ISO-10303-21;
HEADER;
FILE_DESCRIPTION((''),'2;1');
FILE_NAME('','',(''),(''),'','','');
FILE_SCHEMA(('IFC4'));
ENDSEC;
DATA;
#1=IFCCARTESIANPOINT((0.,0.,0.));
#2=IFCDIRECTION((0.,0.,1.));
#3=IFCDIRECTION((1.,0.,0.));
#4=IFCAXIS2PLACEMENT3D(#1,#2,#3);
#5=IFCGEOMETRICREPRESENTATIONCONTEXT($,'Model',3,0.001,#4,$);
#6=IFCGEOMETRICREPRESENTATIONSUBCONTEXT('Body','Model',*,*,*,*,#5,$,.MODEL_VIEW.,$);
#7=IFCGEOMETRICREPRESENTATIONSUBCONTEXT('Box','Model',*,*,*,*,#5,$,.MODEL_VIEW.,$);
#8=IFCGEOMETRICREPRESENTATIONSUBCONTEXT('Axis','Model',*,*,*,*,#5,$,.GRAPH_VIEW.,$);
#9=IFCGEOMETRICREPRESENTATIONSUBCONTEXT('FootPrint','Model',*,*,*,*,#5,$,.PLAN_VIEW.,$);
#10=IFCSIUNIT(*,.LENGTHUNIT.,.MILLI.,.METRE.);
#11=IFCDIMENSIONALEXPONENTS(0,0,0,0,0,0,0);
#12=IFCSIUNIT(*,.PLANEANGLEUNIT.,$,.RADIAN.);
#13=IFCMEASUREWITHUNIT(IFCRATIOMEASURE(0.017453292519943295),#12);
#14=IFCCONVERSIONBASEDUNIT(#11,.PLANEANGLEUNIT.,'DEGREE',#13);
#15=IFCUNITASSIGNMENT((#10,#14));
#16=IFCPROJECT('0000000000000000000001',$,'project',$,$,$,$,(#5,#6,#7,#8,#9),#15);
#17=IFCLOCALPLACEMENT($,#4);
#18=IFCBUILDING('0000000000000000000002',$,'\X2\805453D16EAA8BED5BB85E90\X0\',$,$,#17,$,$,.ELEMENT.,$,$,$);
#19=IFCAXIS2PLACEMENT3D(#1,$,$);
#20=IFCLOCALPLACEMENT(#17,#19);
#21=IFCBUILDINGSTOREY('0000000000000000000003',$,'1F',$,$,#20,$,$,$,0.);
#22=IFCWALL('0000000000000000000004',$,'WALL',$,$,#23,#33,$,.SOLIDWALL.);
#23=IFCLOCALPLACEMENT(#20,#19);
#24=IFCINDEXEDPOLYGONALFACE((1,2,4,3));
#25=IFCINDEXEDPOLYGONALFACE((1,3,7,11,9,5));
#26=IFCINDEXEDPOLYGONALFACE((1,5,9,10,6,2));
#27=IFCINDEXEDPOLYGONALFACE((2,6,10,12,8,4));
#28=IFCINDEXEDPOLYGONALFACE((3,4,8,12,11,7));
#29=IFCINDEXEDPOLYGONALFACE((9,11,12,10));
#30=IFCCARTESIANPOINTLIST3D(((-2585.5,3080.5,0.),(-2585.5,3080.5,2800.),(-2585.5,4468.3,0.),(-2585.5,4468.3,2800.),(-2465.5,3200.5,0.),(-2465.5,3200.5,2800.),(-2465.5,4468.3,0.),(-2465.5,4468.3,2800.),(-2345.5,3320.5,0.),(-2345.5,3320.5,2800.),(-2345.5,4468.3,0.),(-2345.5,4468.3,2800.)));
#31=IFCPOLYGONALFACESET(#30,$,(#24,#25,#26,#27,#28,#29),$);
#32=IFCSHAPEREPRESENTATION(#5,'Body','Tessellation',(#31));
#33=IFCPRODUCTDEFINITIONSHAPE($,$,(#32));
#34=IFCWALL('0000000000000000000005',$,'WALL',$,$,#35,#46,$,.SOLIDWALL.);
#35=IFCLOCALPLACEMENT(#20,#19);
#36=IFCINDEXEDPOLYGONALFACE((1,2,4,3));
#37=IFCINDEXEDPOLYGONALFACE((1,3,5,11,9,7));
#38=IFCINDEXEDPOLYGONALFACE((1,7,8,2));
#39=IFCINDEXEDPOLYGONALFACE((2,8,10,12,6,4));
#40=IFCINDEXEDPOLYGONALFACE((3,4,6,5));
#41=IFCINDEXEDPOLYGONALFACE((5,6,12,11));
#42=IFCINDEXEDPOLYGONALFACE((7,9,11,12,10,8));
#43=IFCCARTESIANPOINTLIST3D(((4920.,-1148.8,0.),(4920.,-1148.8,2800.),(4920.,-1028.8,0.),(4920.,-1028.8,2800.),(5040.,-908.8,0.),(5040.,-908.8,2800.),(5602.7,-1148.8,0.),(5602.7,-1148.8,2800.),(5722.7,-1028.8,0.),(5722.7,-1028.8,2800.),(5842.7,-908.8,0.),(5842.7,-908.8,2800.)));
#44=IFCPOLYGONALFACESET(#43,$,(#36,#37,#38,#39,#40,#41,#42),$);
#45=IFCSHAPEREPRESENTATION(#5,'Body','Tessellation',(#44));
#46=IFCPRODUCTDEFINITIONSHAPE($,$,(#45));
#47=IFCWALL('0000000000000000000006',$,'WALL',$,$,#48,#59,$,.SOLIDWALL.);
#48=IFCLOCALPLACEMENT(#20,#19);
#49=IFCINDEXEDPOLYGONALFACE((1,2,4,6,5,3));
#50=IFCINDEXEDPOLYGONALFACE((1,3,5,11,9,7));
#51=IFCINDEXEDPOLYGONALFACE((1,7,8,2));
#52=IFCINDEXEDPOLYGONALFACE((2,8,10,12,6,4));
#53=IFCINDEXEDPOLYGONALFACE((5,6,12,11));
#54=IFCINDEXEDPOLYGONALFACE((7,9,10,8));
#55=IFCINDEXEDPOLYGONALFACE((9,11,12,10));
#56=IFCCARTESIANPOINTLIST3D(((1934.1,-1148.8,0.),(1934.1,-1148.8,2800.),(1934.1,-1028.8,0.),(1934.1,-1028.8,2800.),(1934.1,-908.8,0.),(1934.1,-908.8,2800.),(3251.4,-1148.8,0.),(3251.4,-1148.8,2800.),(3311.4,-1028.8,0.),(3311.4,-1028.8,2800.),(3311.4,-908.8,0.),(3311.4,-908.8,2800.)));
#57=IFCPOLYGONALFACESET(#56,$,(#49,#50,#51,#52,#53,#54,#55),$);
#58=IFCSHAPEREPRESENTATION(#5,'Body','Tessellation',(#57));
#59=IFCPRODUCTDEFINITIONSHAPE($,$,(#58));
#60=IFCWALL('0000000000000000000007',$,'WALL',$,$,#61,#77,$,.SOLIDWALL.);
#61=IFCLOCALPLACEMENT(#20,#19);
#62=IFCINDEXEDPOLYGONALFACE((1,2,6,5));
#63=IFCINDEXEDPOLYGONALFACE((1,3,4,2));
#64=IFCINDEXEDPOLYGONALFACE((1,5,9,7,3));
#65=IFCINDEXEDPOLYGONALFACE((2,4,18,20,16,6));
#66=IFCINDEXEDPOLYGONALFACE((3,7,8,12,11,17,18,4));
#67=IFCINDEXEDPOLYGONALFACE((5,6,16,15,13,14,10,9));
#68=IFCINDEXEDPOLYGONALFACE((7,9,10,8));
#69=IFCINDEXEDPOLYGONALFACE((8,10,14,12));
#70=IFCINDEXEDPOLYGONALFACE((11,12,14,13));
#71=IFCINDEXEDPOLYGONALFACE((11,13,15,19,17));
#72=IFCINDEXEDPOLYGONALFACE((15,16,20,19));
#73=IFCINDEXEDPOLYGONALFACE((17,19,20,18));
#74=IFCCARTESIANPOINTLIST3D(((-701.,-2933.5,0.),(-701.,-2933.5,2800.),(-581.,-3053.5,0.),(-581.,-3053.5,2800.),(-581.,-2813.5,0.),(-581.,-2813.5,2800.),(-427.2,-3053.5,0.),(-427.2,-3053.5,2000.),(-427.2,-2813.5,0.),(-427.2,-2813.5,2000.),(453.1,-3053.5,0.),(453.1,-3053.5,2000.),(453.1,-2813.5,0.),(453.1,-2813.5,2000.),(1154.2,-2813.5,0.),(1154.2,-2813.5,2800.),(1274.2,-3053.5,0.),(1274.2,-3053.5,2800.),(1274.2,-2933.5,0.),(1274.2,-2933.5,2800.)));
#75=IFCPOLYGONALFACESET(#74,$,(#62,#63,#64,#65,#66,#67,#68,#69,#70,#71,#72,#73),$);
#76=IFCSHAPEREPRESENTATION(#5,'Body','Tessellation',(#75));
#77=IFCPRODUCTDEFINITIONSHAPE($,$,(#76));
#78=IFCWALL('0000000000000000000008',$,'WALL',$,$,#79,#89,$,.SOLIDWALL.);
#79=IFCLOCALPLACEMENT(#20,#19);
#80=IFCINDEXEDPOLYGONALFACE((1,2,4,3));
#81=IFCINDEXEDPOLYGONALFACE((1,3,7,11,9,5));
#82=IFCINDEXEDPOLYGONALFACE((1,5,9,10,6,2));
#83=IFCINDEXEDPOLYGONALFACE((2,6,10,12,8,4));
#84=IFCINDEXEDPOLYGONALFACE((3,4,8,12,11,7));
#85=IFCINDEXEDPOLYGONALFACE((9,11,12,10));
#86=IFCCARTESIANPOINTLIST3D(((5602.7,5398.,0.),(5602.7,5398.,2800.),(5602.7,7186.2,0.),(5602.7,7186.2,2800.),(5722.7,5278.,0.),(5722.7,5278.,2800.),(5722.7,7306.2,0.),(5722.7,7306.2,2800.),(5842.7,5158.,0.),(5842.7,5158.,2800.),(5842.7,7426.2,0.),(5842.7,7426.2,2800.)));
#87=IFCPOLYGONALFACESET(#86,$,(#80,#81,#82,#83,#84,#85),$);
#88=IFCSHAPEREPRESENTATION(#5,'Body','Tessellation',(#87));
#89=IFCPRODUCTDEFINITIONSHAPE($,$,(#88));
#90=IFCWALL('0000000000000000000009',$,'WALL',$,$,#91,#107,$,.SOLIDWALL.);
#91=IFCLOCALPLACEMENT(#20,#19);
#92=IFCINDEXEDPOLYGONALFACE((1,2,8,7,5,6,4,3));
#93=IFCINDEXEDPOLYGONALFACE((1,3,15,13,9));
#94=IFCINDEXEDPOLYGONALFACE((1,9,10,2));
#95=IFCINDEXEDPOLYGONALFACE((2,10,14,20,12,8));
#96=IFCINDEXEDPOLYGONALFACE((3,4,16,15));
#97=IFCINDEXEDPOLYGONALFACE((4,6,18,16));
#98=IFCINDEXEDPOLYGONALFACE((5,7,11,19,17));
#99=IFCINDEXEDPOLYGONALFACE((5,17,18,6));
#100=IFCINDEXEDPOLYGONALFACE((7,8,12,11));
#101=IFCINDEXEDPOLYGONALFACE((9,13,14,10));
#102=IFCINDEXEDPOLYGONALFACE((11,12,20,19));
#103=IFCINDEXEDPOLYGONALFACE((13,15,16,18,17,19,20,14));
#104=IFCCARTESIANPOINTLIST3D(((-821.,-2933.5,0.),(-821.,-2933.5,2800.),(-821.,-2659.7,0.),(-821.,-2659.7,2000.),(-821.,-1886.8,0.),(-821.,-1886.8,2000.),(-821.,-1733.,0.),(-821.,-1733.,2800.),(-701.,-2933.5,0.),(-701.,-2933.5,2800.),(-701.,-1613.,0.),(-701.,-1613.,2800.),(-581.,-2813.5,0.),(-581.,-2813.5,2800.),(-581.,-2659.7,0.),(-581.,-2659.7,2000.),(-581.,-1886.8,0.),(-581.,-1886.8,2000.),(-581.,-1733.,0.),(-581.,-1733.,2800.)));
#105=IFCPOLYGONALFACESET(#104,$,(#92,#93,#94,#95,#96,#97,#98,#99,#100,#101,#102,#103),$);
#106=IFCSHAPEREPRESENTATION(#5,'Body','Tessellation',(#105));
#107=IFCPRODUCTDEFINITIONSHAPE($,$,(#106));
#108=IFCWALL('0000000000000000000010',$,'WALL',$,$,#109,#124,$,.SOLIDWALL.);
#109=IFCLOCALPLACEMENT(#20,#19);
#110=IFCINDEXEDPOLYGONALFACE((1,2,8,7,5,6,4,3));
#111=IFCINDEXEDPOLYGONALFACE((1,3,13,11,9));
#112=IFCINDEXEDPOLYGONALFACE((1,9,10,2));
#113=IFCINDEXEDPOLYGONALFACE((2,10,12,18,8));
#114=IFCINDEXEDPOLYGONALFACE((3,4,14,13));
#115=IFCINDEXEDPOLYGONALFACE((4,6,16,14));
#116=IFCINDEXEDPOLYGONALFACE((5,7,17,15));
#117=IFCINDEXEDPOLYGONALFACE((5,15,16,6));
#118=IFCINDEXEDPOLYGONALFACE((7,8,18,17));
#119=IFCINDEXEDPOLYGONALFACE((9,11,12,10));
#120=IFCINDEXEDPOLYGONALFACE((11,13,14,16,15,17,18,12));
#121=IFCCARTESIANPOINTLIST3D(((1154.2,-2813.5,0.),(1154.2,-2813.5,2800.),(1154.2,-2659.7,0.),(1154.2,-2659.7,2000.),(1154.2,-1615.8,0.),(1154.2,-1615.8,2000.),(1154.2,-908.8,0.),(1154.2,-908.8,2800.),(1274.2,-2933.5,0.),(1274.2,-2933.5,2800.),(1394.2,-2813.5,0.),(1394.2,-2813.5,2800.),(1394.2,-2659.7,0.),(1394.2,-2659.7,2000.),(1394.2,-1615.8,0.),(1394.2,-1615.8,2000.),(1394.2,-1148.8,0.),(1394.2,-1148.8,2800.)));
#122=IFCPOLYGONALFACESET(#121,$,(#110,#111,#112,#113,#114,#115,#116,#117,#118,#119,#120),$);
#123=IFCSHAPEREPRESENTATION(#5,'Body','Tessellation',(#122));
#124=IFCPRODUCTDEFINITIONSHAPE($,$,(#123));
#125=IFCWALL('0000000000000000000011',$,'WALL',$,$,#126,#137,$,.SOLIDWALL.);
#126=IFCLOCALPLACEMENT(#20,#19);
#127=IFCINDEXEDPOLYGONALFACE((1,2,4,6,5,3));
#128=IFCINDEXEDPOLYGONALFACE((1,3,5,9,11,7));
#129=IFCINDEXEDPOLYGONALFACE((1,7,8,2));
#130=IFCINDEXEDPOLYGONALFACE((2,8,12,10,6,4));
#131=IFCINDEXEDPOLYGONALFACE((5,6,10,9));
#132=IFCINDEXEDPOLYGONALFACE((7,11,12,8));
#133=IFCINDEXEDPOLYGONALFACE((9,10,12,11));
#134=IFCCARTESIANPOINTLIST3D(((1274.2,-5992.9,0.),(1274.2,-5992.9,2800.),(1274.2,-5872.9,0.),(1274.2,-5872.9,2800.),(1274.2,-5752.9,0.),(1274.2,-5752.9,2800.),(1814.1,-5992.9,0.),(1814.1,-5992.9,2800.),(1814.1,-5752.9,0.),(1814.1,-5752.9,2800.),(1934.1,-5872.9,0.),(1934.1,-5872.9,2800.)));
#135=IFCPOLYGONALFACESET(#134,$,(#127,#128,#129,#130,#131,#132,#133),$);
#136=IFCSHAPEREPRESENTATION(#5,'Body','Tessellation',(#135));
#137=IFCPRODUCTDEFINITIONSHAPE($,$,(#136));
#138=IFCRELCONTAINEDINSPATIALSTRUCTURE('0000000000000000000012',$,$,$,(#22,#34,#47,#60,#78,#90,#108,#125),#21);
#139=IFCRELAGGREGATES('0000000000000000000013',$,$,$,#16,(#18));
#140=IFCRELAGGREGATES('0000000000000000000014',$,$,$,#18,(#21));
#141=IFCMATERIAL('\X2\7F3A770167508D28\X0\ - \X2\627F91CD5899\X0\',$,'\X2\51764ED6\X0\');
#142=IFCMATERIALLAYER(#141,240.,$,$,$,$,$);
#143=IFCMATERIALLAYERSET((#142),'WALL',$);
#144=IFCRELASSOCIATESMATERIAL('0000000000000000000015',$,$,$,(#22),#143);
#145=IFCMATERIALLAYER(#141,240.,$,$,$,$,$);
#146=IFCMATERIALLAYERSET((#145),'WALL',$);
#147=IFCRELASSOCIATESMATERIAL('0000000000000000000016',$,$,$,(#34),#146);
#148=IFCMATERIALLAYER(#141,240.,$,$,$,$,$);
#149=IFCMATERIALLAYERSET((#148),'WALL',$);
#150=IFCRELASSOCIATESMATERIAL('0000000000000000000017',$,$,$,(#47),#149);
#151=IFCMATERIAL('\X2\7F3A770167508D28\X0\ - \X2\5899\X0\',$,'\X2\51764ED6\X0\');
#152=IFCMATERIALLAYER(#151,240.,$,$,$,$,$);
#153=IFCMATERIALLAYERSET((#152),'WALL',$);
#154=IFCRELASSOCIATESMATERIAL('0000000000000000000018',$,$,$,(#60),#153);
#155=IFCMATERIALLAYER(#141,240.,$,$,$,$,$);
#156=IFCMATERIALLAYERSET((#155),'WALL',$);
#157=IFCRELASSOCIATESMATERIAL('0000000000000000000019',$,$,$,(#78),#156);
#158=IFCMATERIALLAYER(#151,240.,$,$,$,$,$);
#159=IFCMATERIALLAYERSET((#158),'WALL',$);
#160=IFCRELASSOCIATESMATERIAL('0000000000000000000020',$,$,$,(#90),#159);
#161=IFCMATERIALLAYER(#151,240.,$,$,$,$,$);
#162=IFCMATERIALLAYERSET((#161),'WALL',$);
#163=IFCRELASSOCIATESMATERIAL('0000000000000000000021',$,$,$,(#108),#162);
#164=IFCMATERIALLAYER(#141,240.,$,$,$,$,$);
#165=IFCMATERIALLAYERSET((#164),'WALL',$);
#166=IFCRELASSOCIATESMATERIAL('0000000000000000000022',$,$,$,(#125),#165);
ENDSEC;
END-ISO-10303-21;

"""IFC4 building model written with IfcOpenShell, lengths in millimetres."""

from ifc_helpers import new_model, entity, si_unit, converted_unit, origin, origin_with_axes, place, context, subcontext, project, spatial, polyline, segment, composite_curve, outline, extrude, material, layer, layer_set, layer_usage, element, save


model = new_model("IFC4")

# Units and contexts
model_context = context("Model", 3, precision=0.001, world=origin_with_axes())
body_context = subcontext(model_context, "Body", "Model", "MODEL_VIEW")
box_context = subcontext(model_context, "Box", "Model", "MODEL_VIEW")
axis_context = subcontext(model_context, "Axis", "Model", "GRAPH_VIEW")
footprint_context = subcontext(model_context, "FootPrint", "Model", "PLAN_VIEW")
ifc_project = project(units=[si_unit("LENGTHUNIT", "METRE", prefix="MILLI"), converted_unit("PLANEANGLEUNIT", "DEGREE", entity("IfcRatioMeasure", 0.017453292519943295), si_unit("PLANEANGLEUNIT", "RADIAN"), dimensions=[0, 0, 0, 0, 0, 0, 0])], contexts=[model_context, body_context, box_context, axis_context, footprint_context])

# Building, storey
building_placement = place(None, origin_with_axes())
building = spatial("IfcBuilding", under=ifc_project, at=building_placement, Name="联发溪语宸庐", CompositionType="ELEMENT")
storey_placement = place(building_placement, origin())
storey = spatial("IfcBuildingStorey", under=building, at=storey_placement, Name="1F", Elevation=0.0)

# Walls
ifc_material_1 = material(Name="缺省材质 - 承重墙", Category="其他")
ifc_layer_1 = layer(ifc_material_1, 240.0)
ifc_layer_set_1 = layer_set([ifc_layer_1], Name="WALL")
ifc_layer_usage_1 = layer_usage(ifc_layer_set_1, "AXIS2", "NEGATIVE", 120.0)
wall_1_placement = place(None, origin_with_axes())
element("IfcWall", 1, at=wall_1_placement, inside=storey, material=ifc_layer_usage_1, Name="WALL", PredefinedType="SOLIDWALL", context=model_context, shape_type="SweptSolid", body=[
    extrude(outline(composite_curve([segment(polyline([(-2465.5, 3200.5), (-2345.5, 3320.5)]), True, "CONTINUOUS"), segment(polyline([(-2345.5, 3320.5), (-2345.5, 4468.3)]), True, "CONTINUOUS"), segment(polyline([(-2345.5, 4468.3), (-2465.5, 4468.3)]), True, "CONTINUOUS"), segment(polyline([(-2465.5, 4468.3), (-2585.5, 4468.3)]), True, "CONTINUOUS"), segment(polyline([(-2585.5, 4468.3), (-2585.5, 3080.5)]), True, "CONTINUOUS"), segment(polyline([(-2585.5, 3080.5), (-2465.5, 3200.5)]), True, "CONTINUOUS")], self_intersect=False)), origin(), (0.0, 0.0, 1.0), 2800.0),
])
ifc_layer_2 = layer(ifc_material_1, 240.0)
ifc_layer_set_2 = layer_set([ifc_layer_2], Name="WALL")
ifc_layer_usage_2 = layer_usage(ifc_layer_set_2, "AXIS2", "NEGATIVE", 120.0)
wall_2_placement = place(None, origin_with_axes())
element("IfcWall", 2, at=wall_2_placement, inside=storey, material=ifc_layer_usage_2, Name="WALL", PredefinedType="SOLIDWALL", context=model_context, shape_type="SweptSolid", body=[
    extrude(outline(composite_curve([segment(polyline([(5722.7, -1028.8), (5842.7, -908.8)]), True, "CONTINUOUS"), segment(polyline([(5842.7, -908.8), (5040.0, -908.8)]), True, "CONTINUOUS"), segment(polyline([(5040.0, -908.8), (4920.0, -1028.8)]), True, "CONTINUOUS"), segment(polyline([(4920.0, -1028.8), (4920.0, -1148.8)]), True, "CONTINUOUS"), segment(polyline([(4920.0, -1148.8), (5602.7, -1148.8)]), True, "CONTINUOUS"), segment(polyline([(5602.7, -1148.8), (5722.7, -1028.8)]), True, "CONTINUOUS")], self_intersect=False)), origin(), (0.0, 0.0, 1.0), 2800.0),
])
ifc_layer_3 = layer(ifc_material_1, 240.0)
ifc_layer_set_3 = layer_set([ifc_layer_3], Name="WALL")
ifc_layer_usage_3 = layer_usage(ifc_layer_set_3, "AXIS2", "NEGATIVE", 120.0)
wall_3_placement = place(None, origin_with_axes())
element("IfcWall", 3, at=wall_3_placement, inside=storey, material=ifc_layer_usage_3, Name="WALL", PredefinedType="SOLIDWALL", context=model_context, shape_type="SweptSolid", body=[
    extrude(outline(composite_curve([segment(polyline([(3311.4, -1028.8), (3311.4, -908.8)]), True, "CONTINUOUS"), segment(polyline([(3311.4, -908.8), (1934.1, -908.8)]), True, "CONTINUOUS"), segment(polyline([(1934.1, -908.8), (1934.1, -1028.8)]), True, "CONTINUOUS"), segment(polyline([(1934.1, -1028.8), (1934.1, -1148.8)]), True, "CONTINUOUS"), segment(polyline([(1934.1, -1148.8), (3251.4, -1148.8)]), True, "CONTINUOUS"), segment(polyline([(3251.4, -1148.8), (3311.4, -1028.8)]), True, "CONTINUOUS")], self_intersect=False)), origin(), (0.0, 0.0, 1.0), 2800.0),
])

# Wall, opening
ifc_material_2 = material(Name="缺省材质 - 墙", Category="其他")
ifc_layer_4 = layer(ifc_material_2, 240.0)
ifc_layer_set_4 = layer_set([ifc_layer_4], Name="WALL")
ifc_layer_usage_4 = layer_usage(ifc_layer_set_4, "AXIS2", "NEGATIVE", 120.0)
wall_4_placement = place(None, origin_with_axes())
wall_4 = element("IfcWall", 4, at=wall_4_placement, inside=storey, material=ifc_layer_usage_4, Name="WALL", PredefinedType="SOLIDWALL", context=model_context, shape_type="SweptSolid", body=[
    extrude(outline(composite_curve([segment(polyline([(-701.0, -2933.5), (-581.0, -3053.5)]), True, "CONTINUOUS"), segment(polyline([(-581.0, -3053.5), (1274.2, -3053.5)]), True, "CONTINUOUS"), segment(polyline([(1274.2, -3053.5), (1274.2, -2933.5)]), True, "CONTINUOUS"), segment(polyline([(1274.2, -2933.5), (1154.2, -2813.5)]), True, "CONTINUOUS"), segment(polyline([(1154.2, -2813.5), (-581.0, -2813.5)]), True, "CONTINUOUS"), segment(polyline([(-581.0, -2813.5), (-701.0, -2933.5)]), True, "CONTINUOUS")], self_intersect=False)), origin(), (0.0, 0.0, 1.0), 2800.0),
])
opening_1_placement = place(None, origin_with_axes())
element("IfcOpeningElement", 5, at=opening_1_placement, cuts=wall_4, ObjectType="OPENING", PredefinedType="OPENING", context=model_context, shape_type="SweptSolid", body=[
    extrude(outline(composite_curve([segment(polyline([(453.1, -2813.5), (-427.2, -2813.5)]), True, "CONTINUOUS"), segment(polyline([(-427.2, -2813.5), (-427.2, -3053.5)]), True, "CONTINUOUS"), segment(polyline([(-427.2, -3053.5), (453.1, -3053.5)]), True, "CONTINUOUS"), segment(polyline([(453.1, -3053.5), (453.1, -2813.5)]), True, "CONTINUOUS")], self_intersect=False)), origin_with_axes(), (0.0, 0.0, 1.0), 2000.0),
])

# Wall
ifc_layer_5 = layer(ifc_material_1, 240.0)
ifc_layer_set_5 = layer_set([ifc_layer_5], Name="WALL")
ifc_layer_usage_5 = layer_usage(ifc_layer_set_5, "AXIS2", "NEGATIVE", 120.0)
wall_5_placement = place(None, origin_with_axes())
element("IfcWall", 6, at=wall_5_placement, inside=storey, material=ifc_layer_usage_5, Name="WALL", PredefinedType="SOLIDWALL", context=model_context, shape_type="SweptSolid", body=[
    extrude(outline(composite_curve([segment(polyline([(5722.7, 5278.0), (5842.7, 5158.0)]), True, "CONTINUOUS"), segment(polyline([(5842.7, 5158.0), (5842.7, 7426.2)]), True, "CONTINUOUS"), segment(polyline([(5842.7, 7426.2), (5722.7, 7306.2)]), True, "CONTINUOUS"), segment(polyline([(5722.7, 7306.2), (5602.7, 7186.2)]), True, "CONTINUOUS"), segment(polyline([(5602.7, 7186.2), (5602.7, 5398.0)]), True, "CONTINUOUS"), segment(polyline([(5602.7, 5398.0), (5722.7, 5278.0)]), True, "CONTINUOUS")], self_intersect=False)), origin(), (0.0, 0.0, 1.0), 2800.0),
])

# Walls, openings
ifc_layer_6 = layer(ifc_material_2, 240.0)
ifc_layer_set_6 = layer_set([ifc_layer_6], Name="WALL")
ifc_layer_usage_6 = layer_usage(ifc_layer_set_6, "AXIS2", "NEGATIVE", 120.0)
wall_6_placement = place(None, origin_with_axes())
wall_6 = element("IfcWall", 7, at=wall_6_placement, inside=storey, material=ifc_layer_usage_6, Name="WALL", PredefinedType="SOLIDWALL", context=model_context, shape_type="SweptSolid", body=[
    extrude(outline(composite_curve([segment(polyline([(-701.0, -2933.5), (-581.0, -2813.5)]), True, "CONTINUOUS"), segment(polyline([(-581.0, -2813.5), (-581.0, -1733.0)]), True, "CONTINUOUS"), segment(polyline([(-581.0, -1733.0), (-701.0, -1613.0)]), True, "CONTINUOUS"), segment(polyline([(-701.0, -1613.0), (-821.0, -1733.0)]), True, "CONTINUOUS"), segment(polyline([(-821.0, -1733.0), (-821.0, -2933.5)]), True, "CONTINUOUS"), segment(polyline([(-821.0, -2933.5), (-701.0, -2933.5)]), True, "CONTINUOUS")], self_intersect=False)), origin(), (0.0, 0.0, 1.0), 2800.0),
])
opening_2_placement = place(None, origin_with_axes())
element("IfcOpeningElement", 8, at=opening_2_placement, cuts=wall_6, ObjectType="OPENING", PredefinedType="OPENING", context=model_context, shape_type="SweptSolid", body=[
    extrude(outline(composite_curve([segment(polyline([(-821.0, -1886.8), (-821.0, -2659.7)]), True, "CONTINUOUS"), segment(polyline([(-821.0, -2659.7), (-581.0, -2659.7)]), True, "CONTINUOUS"), segment(polyline([(-581.0, -2659.7), (-581.0, -1886.8)]), True, "CONTINUOUS"), segment(polyline([(-581.0, -1886.8), (-821.0, -1886.8)]), True, "CONTINUOUS")], self_intersect=False)), origin_with_axes(), (0.0, 0.0, 1.0), 2000.0),
])
ifc_layer_7 = layer(ifc_material_2, 240.0)
ifc_layer_set_7 = layer_set([ifc_layer_7], Name="WALL")
ifc_layer_usage_7 = layer_usage(ifc_layer_set_7, "AXIS2", "NEGATIVE", 120.0)
wall_7_placement = place(None, origin_with_axes())
wall_7 = element("IfcWall", 9, at=wall_7_placement, inside=storey, material=ifc_layer_usage_7, Name="WALL", PredefinedType="SOLIDWALL", context=model_context, shape_type="SweptSolid", body=[
    extrude(outline(composite_curve([segment(polyline([(1274.2, -2933.5), (1394.2, -2813.5)]), True, "CONTINUOUS"), segment(polyline([(1394.2, -2813.5), (1394.2, -1148.8)]), True, "CONTINUOUS"), segment(polyline([(1394.2, -1148.8), (1274.2, -1028.8)]), True, "CONTINUOUS"), segment(polyline([(1274.2, -1028.8), (1154.2, -908.8)]), True, "CONTINUOUS"), segment(polyline([(1154.2, -908.8), (1154.2, -2813.5)]), True, "CONTINUOUS"), segment(polyline([(1154.2, -2813.5), (1274.2, -2933.5)]), True, "CONTINUOUS")], self_intersect=False)), origin(), (0.0, 0.0, 1.0), 2800.0),
])
opening_3_placement = place(None, origin_with_axes())
element("IfcOpeningElement", 10, at=opening_3_placement, cuts=wall_7, ObjectType="OPENING", PredefinedType="OPENING", context=model_context, shape_type="SweptSolid", body=[
    extrude(outline(composite_curve([segment(polyline([(1154.2, -1615.8), (1154.2, -2659.7)]), True, "CONTINUOUS"), segment(polyline([(1154.2, -2659.7), (1394.2, -2659.7)]), True, "CONTINUOUS"), segment(polyline([(1394.2, -2659.7), (1394.2, -1615.8)]), True, "CONTINUOUS"), segment(polyline([(1394.2, -1615.8), (1154.2, -1615.8)]), True, "CONTINUOUS")], self_intersect=False)), origin_with_axes(), (0.0, 0.0, 1.0), 2000.0),
])

# Wall
ifc_layer_8 = layer(ifc_material_1, 240.0)
ifc_layer_set_8 = layer_set([ifc_layer_8], Name="WALL")
ifc_layer_usage_8 = layer_usage(ifc_layer_set_8, "AXIS2", "NEGATIVE", 120.0)
wall_8_placement = place(None, origin_with_axes())
element("IfcWall", 11, at=wall_8_placement, inside=storey, material=ifc_layer_usage_8, Name="WALL", PredefinedType="SOLIDWALL", context=model_context, shape_type="SweptSolid", body=[
    extrude(outline(composite_curve([segment(polyline([(1274.2, -5872.9), (1274.2, -5992.9)]), True, "CONTINUOUS"), segment(polyline([(1274.2, -5992.9), (1814.1, -5992.9)]), True, "CONTINUOUS"), segment(polyline([(1814.1, -5992.9), (1934.1, -5872.9)]), True, "CONTINUOUS"), segment(polyline([(1934.1, -5872.9), (1814.1, -5752.9)]), True, "CONTINUOUS"), segment(polyline([(1814.1, -5752.9), (1274.2, -5752.9)]), True, "CONTINUOUS"), segment(polyline([(1274.2, -5752.9), (1274.2, -5872.9)]), True, "CONTINUOUS")], self_intersect=False)), origin(), (0.0, 0.0, 1.0), 2800.0),
])

save(model, "model.ifc")
